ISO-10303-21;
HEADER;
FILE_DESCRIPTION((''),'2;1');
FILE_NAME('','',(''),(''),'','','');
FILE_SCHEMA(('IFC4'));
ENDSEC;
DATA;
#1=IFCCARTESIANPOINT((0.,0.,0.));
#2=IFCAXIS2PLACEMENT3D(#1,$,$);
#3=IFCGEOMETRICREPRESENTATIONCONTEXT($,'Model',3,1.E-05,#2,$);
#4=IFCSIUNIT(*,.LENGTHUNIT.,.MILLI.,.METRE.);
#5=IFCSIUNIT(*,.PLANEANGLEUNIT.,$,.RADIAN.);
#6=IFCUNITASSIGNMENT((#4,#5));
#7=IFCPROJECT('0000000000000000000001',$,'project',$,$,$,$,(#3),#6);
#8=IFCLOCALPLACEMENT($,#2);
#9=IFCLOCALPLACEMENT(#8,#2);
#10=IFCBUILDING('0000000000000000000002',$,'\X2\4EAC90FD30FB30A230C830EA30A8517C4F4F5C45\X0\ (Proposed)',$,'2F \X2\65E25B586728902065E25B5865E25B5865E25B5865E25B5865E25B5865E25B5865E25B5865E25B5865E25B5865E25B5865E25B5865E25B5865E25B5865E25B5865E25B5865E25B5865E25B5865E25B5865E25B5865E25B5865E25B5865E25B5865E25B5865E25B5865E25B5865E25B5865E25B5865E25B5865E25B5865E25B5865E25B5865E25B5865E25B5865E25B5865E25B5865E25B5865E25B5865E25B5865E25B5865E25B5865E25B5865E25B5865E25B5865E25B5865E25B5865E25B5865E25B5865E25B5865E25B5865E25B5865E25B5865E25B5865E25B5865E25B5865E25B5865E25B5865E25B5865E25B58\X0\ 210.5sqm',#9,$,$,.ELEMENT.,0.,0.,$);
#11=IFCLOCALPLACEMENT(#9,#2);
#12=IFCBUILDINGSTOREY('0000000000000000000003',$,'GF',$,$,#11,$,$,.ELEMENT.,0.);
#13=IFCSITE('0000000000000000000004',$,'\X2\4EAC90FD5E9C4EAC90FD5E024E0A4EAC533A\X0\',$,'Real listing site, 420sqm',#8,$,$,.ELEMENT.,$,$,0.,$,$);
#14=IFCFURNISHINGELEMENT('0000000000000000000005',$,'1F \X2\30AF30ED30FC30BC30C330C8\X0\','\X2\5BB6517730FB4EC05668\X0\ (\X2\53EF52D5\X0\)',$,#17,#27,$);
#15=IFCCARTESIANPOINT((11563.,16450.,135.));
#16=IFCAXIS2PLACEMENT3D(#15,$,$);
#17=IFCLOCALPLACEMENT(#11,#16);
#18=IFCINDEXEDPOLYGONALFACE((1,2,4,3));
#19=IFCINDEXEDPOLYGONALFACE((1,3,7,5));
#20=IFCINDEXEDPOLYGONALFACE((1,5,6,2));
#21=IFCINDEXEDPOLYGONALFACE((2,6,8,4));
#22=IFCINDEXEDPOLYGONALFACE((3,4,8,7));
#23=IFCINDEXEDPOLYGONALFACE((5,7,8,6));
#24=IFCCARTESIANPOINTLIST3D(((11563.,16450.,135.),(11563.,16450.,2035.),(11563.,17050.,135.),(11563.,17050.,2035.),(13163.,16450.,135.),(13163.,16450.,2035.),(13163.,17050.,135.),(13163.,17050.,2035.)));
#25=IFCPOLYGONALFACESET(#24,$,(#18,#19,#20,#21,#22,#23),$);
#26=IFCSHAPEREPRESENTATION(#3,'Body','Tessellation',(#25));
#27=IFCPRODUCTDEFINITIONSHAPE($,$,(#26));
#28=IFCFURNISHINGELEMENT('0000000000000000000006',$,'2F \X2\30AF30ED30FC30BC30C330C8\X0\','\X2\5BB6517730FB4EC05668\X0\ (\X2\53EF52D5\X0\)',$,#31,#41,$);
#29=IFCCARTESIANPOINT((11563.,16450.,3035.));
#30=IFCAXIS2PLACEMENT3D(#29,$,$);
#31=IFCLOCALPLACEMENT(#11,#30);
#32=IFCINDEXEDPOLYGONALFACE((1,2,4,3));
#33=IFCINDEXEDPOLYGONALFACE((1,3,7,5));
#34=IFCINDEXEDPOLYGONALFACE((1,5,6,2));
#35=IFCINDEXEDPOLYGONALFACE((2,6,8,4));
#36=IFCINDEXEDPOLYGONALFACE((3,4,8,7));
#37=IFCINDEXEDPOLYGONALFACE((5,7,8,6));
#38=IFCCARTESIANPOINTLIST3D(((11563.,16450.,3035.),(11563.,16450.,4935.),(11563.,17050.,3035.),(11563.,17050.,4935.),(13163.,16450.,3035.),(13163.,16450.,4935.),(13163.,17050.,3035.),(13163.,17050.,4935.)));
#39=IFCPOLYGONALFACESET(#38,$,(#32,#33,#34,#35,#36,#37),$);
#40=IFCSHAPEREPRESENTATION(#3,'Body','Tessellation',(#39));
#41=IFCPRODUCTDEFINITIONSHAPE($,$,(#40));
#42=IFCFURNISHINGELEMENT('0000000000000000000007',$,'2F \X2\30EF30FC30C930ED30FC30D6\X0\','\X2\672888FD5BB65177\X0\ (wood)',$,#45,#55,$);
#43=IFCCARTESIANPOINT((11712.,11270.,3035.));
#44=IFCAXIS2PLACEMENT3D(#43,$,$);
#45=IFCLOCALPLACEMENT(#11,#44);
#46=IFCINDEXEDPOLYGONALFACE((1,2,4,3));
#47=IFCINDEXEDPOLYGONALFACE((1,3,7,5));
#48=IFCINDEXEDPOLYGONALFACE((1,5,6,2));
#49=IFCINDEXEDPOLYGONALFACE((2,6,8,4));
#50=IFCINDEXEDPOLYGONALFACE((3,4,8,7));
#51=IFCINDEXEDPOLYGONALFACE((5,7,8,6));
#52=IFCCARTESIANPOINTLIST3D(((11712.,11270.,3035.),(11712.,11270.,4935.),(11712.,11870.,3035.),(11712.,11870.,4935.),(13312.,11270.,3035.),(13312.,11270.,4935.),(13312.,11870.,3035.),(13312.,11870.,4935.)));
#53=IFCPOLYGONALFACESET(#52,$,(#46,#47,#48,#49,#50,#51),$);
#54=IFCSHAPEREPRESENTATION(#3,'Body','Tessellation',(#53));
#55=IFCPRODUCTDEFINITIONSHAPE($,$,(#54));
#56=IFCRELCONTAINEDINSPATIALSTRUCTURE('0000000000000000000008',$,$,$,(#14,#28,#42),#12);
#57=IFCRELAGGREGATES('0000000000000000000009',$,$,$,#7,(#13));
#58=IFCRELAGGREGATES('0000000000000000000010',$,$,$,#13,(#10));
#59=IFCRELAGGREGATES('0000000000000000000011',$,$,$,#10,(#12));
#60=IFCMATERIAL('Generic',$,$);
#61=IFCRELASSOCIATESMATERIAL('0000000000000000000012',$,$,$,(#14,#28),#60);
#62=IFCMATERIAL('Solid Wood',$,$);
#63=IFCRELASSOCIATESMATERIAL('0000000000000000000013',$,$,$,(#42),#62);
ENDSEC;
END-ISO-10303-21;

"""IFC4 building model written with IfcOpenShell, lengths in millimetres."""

from ifc_helpers import new_model, si_unit, frame, frame_2d, origin, place, context, project, spatial, rectangle, extrude, material, element, save


model = new_model("IFC4")

# Units and contexts
model_context = context("Model", 3, precision=1e-05, world=origin())
ifc_project = project(units=[si_unit("LENGTHUNIT", "METRE", prefix="MILLI"), si_unit("PLANEANGLEUNIT", "RADIAN")], contexts=[model_context])

# Site, building, storey
site_placement = place(None, origin())
site = spatial("IfcSite", under=ifc_project, at=site_placement, Name="京都府京都市上京区", ObjectType="Real listing site, 420sqm", CompositionType="ELEMENT", RefElevation=0.0)
building_placement = place(site_placement, origin())
building = spatial("IfcBuilding", under=site, at=building_placement, Name="京都・アトリエ兼住居 (Proposed)", ObjectType="2F 既存木造既存既存既存既存既存既存既存既存既存既存既存既存既存既存既存既存既存既存既存既存既存既存既存既存既存既存既存既存既存既存既存既存既存既存既存既存既存既存既存既存既存既存既存既存既存既存既存既存既存既存既存既存既存既存既存既存既存既存 210.5sqm", CompositionType="ELEMENT", ElevationOfRefHeight=0.0, ElevationOfTerrain=0.0)
storey_placement = place(building_placement, origin())
storey = spatial("IfcBuildingStorey", under=building, at=storey_placement, Name="GF", CompositionType="ELEMENT", Elevation=0.0)

# Shared definitions
ifc_material_1 = material(Name="Solid Wood")

# Shared definitions
ifc_material_2 = material(Name="Generic")

# Furnishing elements
furnishing_1_placement = place(storey_placement, frame((11563.0, 16450.0, 135.0)))
element("IfcFurnishingElement", 1, at=furnishing_1_placement, inside=storey, material=ifc_material_2, Name="1F クローゼット", Description="家具・什器 (可動)", context=model_context, shape_type="SweptSolid", body=[
    extrude(rectangle(XDim=1600.0, YDim=600.0, at=frame_2d((800.0, 300.0))), frame((11563.0, 16450.0, 135.0)), (0.0, 0.0, 1.0), 1900.0),
])
furnishing_2_placement = place(storey_placement, frame((11563.0, 16450.0, 3035.0)))
element("IfcFurnishingElement", 2, at=furnishing_2_placement, inside=storey, material=ifc_material_2, Name="2F クローゼット", Description="家具・什器 (可動)", context=model_context, shape_type="SweptSolid", body=[
    extrude(rectangle(XDim=1600.0, YDim=600.0, at=frame_2d((800.0, 300.0))), frame((11563.0, 16450.0, 3035.0)), (0.0, 0.0, 1.0), 1900.0),
])
furnishing_3_placement = place(storey_placement, frame((11712.0, 11270.0, 3035.0)))
element("IfcFurnishingElement", 3, at=furnishing_3_placement, inside=storey, material=ifc_material_1, Name="2F ワードローブ", Description="木製家具 (wood)", context=model_context, shape_type="SweptSolid", body=[
    extrude(rectangle(XDim=1600.0, YDim=600.0, at=frame_2d((800.0, 300.0))), frame((11712.0, 11270.0, 3035.0)), (0.0, 0.0, 1.0), 1900.0),
])

save(model, "model.ifc")
